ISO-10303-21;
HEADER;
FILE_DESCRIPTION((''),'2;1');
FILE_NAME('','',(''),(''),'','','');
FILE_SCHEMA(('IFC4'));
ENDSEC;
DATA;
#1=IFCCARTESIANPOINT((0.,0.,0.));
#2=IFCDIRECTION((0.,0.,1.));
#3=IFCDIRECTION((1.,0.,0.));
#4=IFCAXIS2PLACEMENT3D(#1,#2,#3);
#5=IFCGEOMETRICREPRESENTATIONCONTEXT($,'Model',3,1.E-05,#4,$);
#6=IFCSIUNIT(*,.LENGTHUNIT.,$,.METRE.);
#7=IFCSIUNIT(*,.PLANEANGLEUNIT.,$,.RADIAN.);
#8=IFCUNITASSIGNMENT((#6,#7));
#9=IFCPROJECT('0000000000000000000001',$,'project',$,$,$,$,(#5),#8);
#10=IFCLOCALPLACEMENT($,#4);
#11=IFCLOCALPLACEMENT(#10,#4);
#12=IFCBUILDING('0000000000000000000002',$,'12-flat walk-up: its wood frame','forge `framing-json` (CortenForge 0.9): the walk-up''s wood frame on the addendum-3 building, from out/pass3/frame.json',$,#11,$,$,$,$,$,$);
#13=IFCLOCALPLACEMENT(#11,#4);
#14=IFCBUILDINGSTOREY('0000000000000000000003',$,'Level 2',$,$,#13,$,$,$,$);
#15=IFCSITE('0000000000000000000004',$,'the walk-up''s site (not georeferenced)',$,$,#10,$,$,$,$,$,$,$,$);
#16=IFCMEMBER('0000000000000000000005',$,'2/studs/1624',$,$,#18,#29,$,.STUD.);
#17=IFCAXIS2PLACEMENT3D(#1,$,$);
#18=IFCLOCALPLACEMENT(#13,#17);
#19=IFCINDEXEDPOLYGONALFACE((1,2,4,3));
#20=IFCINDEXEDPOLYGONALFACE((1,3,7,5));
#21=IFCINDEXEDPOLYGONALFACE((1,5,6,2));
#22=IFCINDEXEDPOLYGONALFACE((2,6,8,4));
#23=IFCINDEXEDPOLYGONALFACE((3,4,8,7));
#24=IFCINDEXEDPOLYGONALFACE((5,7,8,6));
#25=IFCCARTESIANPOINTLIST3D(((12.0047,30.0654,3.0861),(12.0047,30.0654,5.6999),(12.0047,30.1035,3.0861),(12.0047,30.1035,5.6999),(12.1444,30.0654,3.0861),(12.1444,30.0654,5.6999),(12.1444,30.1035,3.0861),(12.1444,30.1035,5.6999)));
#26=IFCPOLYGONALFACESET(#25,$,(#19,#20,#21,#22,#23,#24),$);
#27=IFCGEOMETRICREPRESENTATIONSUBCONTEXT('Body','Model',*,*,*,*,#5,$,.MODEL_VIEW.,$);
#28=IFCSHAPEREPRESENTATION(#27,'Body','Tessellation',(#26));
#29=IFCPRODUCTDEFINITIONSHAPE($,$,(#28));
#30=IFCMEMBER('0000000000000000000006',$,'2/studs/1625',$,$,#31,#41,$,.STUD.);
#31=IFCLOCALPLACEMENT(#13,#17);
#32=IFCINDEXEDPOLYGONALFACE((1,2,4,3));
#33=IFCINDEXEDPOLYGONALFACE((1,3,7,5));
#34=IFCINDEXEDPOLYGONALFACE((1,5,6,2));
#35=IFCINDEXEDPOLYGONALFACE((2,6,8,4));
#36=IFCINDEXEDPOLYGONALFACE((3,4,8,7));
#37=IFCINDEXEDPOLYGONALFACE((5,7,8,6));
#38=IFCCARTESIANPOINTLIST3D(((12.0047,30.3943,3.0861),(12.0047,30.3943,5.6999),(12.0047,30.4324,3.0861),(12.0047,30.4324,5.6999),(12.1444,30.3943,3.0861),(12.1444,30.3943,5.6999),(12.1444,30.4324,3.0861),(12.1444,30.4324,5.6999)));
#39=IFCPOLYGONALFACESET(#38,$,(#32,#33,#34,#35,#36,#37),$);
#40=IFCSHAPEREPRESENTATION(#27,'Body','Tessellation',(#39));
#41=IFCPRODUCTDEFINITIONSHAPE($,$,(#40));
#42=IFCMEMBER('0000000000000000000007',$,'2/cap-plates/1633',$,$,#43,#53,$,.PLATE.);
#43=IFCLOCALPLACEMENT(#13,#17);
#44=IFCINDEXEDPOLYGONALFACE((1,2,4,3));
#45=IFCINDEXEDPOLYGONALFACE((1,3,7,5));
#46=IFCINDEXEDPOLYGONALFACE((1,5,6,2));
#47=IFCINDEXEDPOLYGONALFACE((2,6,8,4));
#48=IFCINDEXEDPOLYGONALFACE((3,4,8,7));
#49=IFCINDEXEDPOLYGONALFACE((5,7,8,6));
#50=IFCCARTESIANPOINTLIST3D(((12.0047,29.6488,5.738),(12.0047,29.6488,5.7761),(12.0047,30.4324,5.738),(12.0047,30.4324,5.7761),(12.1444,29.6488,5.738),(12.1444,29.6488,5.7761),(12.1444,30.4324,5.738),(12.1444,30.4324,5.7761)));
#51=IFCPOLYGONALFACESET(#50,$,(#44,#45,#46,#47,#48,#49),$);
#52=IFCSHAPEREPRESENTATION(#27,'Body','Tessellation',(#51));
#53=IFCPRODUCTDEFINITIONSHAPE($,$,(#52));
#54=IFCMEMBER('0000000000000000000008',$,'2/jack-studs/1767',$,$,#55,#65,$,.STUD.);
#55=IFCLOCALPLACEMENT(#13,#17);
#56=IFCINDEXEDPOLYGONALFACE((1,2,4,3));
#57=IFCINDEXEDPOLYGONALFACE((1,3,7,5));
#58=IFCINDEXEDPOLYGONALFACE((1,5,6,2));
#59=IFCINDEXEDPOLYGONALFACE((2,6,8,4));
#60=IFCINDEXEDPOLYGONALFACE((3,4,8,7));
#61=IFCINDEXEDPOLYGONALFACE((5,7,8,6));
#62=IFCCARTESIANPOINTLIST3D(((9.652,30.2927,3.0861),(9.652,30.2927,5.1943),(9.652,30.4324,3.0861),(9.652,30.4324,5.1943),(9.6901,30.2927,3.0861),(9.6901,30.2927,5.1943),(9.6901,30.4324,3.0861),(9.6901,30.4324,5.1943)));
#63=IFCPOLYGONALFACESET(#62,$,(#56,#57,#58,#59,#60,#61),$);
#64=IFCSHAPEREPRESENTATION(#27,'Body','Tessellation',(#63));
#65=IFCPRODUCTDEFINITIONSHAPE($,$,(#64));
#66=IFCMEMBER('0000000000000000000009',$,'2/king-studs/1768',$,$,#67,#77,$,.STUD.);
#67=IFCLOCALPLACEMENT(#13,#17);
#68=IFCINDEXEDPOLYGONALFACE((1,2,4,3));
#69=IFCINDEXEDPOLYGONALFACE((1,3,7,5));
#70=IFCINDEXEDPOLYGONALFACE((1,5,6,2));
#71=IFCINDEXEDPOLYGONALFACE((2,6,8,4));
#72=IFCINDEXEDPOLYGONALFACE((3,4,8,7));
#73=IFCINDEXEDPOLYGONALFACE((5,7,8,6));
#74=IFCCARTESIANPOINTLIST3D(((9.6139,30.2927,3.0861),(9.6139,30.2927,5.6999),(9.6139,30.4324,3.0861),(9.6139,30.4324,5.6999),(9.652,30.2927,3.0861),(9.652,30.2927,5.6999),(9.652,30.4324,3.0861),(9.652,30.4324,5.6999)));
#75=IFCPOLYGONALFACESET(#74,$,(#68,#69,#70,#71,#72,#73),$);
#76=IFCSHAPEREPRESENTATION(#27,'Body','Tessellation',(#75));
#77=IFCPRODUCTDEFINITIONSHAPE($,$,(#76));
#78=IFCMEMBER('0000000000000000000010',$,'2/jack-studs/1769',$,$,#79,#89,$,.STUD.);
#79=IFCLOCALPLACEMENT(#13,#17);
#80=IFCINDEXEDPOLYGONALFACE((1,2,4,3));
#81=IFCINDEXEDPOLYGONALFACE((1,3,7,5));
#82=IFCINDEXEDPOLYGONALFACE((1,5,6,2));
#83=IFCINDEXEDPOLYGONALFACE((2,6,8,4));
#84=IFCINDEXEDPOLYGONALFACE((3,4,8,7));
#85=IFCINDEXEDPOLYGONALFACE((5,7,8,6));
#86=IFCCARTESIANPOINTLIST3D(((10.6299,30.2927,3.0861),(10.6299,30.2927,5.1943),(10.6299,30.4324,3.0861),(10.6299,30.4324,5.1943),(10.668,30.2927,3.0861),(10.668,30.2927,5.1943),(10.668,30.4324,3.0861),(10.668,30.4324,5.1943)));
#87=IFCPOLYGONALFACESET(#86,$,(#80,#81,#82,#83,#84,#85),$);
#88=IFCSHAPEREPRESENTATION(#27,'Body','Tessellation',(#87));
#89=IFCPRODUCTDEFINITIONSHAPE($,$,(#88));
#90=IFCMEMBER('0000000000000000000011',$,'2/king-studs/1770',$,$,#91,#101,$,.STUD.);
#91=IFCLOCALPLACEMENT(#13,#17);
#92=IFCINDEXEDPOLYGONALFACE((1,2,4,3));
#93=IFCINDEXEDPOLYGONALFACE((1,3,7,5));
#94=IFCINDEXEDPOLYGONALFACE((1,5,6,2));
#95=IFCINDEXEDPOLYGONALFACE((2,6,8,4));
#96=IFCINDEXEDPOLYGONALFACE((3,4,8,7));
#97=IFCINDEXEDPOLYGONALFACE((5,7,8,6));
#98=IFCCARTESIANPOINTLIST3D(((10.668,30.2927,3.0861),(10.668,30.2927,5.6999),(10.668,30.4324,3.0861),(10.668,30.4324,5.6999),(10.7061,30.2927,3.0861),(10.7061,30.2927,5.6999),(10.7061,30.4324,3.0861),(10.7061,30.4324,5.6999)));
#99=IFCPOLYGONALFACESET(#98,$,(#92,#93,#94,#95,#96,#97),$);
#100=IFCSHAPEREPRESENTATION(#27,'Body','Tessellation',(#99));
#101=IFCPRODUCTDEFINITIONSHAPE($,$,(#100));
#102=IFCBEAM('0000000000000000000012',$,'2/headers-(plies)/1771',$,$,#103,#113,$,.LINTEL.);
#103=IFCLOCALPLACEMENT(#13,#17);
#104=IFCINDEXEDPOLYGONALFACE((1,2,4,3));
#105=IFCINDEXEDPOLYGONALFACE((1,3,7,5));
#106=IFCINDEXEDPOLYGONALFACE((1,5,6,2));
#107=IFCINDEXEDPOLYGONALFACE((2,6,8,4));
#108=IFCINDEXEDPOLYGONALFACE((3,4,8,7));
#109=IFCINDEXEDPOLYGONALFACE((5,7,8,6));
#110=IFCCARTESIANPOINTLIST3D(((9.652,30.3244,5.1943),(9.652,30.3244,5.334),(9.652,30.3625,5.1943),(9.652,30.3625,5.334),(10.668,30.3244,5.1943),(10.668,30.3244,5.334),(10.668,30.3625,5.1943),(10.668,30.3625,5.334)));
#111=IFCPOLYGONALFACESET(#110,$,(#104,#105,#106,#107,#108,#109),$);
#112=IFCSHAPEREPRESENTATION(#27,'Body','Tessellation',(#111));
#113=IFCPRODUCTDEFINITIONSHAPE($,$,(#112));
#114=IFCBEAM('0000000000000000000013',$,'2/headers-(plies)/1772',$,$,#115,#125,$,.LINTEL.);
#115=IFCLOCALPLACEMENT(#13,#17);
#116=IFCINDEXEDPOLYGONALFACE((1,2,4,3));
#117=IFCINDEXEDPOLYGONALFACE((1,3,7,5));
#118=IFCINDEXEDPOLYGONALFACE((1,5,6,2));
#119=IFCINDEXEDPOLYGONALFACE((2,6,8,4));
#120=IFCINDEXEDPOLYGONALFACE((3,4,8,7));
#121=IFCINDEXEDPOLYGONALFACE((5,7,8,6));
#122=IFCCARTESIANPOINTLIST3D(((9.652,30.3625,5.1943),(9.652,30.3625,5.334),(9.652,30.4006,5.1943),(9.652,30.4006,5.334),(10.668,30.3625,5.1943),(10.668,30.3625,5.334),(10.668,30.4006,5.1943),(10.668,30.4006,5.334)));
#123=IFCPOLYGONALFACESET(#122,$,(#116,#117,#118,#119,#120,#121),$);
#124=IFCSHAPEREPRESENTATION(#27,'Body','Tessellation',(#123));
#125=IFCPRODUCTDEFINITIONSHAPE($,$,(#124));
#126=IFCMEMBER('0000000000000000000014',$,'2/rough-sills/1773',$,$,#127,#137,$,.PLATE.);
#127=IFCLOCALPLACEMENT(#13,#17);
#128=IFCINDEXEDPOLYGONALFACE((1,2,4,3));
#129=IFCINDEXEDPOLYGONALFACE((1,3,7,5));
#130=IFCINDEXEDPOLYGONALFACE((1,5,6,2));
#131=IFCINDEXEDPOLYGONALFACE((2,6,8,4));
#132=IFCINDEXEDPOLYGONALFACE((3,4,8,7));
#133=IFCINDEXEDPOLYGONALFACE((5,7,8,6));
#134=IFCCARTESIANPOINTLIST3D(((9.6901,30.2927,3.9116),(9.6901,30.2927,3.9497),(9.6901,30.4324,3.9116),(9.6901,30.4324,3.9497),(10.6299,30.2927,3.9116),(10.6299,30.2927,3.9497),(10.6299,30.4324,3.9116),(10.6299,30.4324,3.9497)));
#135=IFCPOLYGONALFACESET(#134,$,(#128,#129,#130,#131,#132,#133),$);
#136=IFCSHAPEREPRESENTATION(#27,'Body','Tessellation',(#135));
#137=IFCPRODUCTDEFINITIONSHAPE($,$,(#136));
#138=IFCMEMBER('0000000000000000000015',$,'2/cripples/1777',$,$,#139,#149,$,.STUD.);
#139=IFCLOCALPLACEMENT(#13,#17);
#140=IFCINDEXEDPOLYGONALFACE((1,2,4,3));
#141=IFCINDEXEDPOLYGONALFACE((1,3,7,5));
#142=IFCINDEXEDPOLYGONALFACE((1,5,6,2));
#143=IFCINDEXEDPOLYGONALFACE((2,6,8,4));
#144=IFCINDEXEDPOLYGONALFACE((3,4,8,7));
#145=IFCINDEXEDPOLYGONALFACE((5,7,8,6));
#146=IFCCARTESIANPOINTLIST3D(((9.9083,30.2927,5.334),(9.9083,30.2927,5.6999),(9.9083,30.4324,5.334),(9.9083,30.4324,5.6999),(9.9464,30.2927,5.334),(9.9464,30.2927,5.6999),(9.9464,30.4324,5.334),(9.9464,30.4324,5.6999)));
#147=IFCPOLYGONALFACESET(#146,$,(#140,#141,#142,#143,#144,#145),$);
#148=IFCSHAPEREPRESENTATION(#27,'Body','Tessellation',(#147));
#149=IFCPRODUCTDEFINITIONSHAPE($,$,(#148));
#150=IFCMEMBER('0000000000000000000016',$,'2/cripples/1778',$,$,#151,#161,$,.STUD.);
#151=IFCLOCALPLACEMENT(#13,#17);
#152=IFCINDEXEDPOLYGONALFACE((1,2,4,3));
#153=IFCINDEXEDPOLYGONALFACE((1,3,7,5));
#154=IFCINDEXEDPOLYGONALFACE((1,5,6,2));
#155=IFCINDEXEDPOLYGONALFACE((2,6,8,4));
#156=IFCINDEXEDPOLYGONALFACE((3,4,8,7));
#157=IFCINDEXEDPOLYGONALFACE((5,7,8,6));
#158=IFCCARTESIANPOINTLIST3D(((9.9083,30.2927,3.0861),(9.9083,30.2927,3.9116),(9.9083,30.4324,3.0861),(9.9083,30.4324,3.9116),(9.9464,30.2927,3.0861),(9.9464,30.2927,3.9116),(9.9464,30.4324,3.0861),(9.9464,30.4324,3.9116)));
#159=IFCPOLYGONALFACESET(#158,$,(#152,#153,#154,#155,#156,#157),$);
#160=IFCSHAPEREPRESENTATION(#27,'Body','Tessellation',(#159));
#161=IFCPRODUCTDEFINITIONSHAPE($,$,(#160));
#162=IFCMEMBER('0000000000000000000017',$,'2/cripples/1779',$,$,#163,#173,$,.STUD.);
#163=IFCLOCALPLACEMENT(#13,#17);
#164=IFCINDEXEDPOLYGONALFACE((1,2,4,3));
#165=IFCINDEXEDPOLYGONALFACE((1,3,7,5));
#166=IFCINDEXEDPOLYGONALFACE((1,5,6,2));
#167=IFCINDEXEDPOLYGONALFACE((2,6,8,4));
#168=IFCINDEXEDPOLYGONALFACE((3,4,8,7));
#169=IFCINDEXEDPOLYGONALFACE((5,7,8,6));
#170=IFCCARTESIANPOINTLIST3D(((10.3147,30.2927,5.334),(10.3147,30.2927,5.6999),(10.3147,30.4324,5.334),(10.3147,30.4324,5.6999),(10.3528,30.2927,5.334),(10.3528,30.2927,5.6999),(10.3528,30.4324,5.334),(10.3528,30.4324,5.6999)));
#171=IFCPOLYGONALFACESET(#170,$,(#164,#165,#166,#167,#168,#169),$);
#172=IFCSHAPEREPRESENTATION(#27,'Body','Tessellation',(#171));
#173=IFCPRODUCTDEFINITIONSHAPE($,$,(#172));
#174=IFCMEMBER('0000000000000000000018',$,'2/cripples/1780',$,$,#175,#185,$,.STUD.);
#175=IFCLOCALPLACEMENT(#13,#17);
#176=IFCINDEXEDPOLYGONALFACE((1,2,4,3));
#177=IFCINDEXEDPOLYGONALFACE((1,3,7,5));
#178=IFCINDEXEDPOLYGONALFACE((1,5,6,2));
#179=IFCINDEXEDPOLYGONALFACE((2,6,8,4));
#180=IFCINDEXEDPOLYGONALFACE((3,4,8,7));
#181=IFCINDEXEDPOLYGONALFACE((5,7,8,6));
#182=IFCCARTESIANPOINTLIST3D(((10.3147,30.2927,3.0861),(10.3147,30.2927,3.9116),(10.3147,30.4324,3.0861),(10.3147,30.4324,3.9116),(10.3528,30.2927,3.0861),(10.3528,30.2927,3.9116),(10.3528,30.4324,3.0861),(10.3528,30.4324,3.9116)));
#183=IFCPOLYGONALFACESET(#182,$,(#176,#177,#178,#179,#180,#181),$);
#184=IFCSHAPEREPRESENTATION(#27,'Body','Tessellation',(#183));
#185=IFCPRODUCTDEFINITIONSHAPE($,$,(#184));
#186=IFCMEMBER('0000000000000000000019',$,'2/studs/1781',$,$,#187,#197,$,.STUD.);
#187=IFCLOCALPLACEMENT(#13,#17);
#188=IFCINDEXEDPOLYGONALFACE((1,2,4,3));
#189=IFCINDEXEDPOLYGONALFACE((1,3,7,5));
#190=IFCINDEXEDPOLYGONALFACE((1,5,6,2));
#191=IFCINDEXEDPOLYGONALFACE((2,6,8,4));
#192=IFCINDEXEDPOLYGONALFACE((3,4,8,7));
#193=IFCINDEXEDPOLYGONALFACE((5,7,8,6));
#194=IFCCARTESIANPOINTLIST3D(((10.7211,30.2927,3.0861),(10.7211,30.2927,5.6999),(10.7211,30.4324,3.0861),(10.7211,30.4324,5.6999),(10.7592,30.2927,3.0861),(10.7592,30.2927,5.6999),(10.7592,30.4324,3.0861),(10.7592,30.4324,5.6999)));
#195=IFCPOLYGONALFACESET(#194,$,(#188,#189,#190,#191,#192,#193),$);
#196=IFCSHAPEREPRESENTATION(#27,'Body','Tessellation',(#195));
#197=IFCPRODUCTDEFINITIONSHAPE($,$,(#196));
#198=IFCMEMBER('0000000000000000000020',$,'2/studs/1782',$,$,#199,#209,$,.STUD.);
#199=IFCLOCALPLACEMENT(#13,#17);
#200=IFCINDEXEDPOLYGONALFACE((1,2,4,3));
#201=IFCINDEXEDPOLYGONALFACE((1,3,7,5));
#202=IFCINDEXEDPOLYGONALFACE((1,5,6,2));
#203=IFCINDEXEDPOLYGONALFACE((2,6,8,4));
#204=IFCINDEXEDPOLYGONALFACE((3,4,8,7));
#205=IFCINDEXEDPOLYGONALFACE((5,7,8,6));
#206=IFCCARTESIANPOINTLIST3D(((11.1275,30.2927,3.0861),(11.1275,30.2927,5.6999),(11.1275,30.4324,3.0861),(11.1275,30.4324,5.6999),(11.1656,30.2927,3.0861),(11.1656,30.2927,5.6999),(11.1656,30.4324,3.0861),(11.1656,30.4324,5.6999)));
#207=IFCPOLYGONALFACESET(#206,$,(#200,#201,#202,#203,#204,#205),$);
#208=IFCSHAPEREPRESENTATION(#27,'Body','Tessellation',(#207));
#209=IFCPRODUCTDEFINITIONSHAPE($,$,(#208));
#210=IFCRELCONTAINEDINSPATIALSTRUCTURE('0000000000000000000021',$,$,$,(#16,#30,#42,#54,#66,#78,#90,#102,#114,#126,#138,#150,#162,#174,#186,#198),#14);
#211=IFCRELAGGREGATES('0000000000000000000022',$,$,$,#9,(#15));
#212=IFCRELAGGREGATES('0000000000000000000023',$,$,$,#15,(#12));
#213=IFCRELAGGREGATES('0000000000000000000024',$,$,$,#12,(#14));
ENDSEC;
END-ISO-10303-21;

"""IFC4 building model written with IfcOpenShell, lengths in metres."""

from ifc_helpers import new_model, si_unit, frame, frame_2d, origin, origin_with_axes, place, context, subcontext, project, spatial, rectangle, extrude, element, save


model = new_model("IFC4")

# Units and contexts
model_context = context("Model", 3, precision=1e-05, world=origin_with_axes())
body_context = subcontext(model_context, "Body", "Model", "MODEL_VIEW")
ifc_project = project(units=[si_unit("LENGTHUNIT", "METRE"), si_unit("PLANEANGLEUNIT", "RADIAN")], contexts=[model_context])

# Site, building, storey
site_placement = place(None, origin_with_axes())
site = spatial("IfcSite", under=ifc_project, at=site_placement, Name="the walk-up's site (not georeferenced)")
building_placement = place(site_placement, origin_with_axes())
building = spatial("IfcBuilding", under=site, at=building_placement, Name="12-flat walk-up: its wood frame", Description="forge `framing-json` (CortenForge 0.9): the walk-up's wood frame on the addendum-3 building, from out/pass3/frame.json")
storey_placement = place(building_placement, origin_with_axes())
storey = spatial("IfcBuildingStorey", under=building, at=storey_placement, Name="Level 2")

# Members
for number, where, z_axis, x_axis, name in (
    (1, (12.0047, 30.0654, 3.0861), (0.0, 0.0, 1.0), (1.0, 0.0, 0.0), "2/studs/1624"),
    (2, (12.0047, 30.3943, 3.0861), (0.0, 0.0, 1.0), (1.0, 0.0, 0.0), "2/studs/1625"),
):
    element("IfcMember", number, at=place(storey_placement, frame(where, z_axis=z_axis, x_axis=x_axis)), inside=storey, Name=name, PredefinedType="STUD", context=body_context, shape_type="SweptSolid", body=[
        extrude(rectangle(XDim=0.1397, YDim=0.0381, at=frame_2d((0.0698, 0.0191))), origin(), (0.0, 0.0, 1.0), 2.6138),
    ])
member_1_placement = place(storey_placement, frame((12.0047, 29.6488, 5.738), z_axis=(0.0, 0.0, 1.0), x_axis=(1.0, 0.0, 0.0)))
element("IfcMember", 3, at=member_1_placement, inside=storey, Name="2/cap-plates/1633", PredefinedType="PLATE", context=body_context, shape_type="SweptSolid", body=[
    extrude(rectangle(XDim=0.1397, YDim=0.7836, at=frame_2d((0.0698, 0.3918))), origin(), (0.0, 0.0, 1.0), 0.0381),
])
member_2_placement = place(storey_placement, frame((9.652, 30.2927, 3.0861), z_axis=(0.0, 0.0, 1.0), x_axis=(1.0, 0.0, 0.0)))
element("IfcMember", 4, at=member_2_placement, inside=storey, Name="2/jack-studs/1767", PredefinedType="STUD", context=body_context, shape_type="SweptSolid", body=[
    extrude(rectangle(XDim=0.0381, YDim=0.1397, at=frame_2d((0.0191, 0.0699))), origin(), (0.0, 0.0, 1.0), 2.1082),
])
member_3_placement = place(storey_placement, frame((9.6139, 30.2927, 3.0861), z_axis=(0.0, 0.0, 1.0), x_axis=(1.0, 0.0, 0.0)))
element("IfcMember", 5, at=member_3_placement, inside=storey, Name="2/king-studs/1768", PredefinedType="STUD", context=body_context, shape_type="SweptSolid", body=[
    extrude(rectangle(XDim=0.0381, YDim=0.1397, at=frame_2d((0.0191, 0.0699))), origin(), (0.0, 0.0, 1.0), 2.6138),
])
member_4_placement = place(storey_placement, frame((10.6299, 30.2927, 3.0861), z_axis=(0.0, 0.0, 1.0), x_axis=(1.0, 0.0, 0.0)))
element("IfcMember", 6, at=member_4_placement, inside=storey, Name="2/jack-studs/1769", PredefinedType="STUD", context=body_context, shape_type="SweptSolid", body=[
    extrude(rectangle(XDim=0.0381, YDim=0.1397, at=frame_2d((0.0191, 0.0699))), origin(), (0.0, 0.0, 1.0), 2.1082),
])
member_5_placement = place(storey_placement, frame((10.668, 30.2927, 3.0861), z_axis=(0.0, 0.0, 1.0), x_axis=(1.0, 0.0, 0.0)))
element("IfcMember", 7, at=member_5_placement, inside=storey, Name="2/king-studs/1770", PredefinedType="STUD", context=body_context, shape_type="SweptSolid", body=[
    extrude(rectangle(XDim=0.0381, YDim=0.1397, at=frame_2d((0.0191, 0.0699))), origin(), (0.0, 0.0, 1.0), 2.6138),
])

# Beams
for number, where, z_axis, x_axis, name in (
    (8, (9.652, 30.3244, 5.1943), (0.0, 0.0, 1.0), (1.0, 0.0, 0.0), "2/headers-(plies)/1771"),
    (9, (9.652, 30.3625, 5.1943), (0.0, 0.0, 1.0), (1.0, 0.0, 0.0), "2/headers-(plies)/1772"),
):
    element("IfcBeam", number, at=place(storey_placement, frame(where, z_axis=z_axis, x_axis=x_axis)), inside=storey, Name=name, PredefinedType="LINTEL", context=body_context, shape_type="SweptSolid", body=[
        extrude(rectangle(XDim=1.016, YDim=0.0381, at=frame_2d((0.508, 0.0191))), origin(), (0.0, 0.0, 1.0), 0.1397),
    ])

# Members
member_6_placement = place(storey_placement, frame((9.6901, 30.2927, 3.9116), z_axis=(0.0, 0.0, 1.0), x_axis=(1.0, 0.0, 0.0)))
element("IfcMember", 10, at=member_6_placement, inside=storey, Name="2/rough-sills/1773", PredefinedType="PLATE", context=body_context, shape_type="SweptSolid", body=[
    extrude(rectangle(XDim=0.9398, YDim=0.1397, at=frame_2d((0.4699, 0.0699))), origin(), (0.0, 0.0, 1.0), 0.0381),
])
member_7_placement = place(storey_placement, frame((9.9083, 30.2927, 5.334), z_axis=(0.0, 0.0, 1.0), x_axis=(1.0, 0.0, 0.0)))
element("IfcMember", 11, at=member_7_placement, inside=storey, Name="2/cripples/1777", PredefinedType="STUD", context=body_context, shape_type="SweptSolid", body=[
    extrude(rectangle(XDim=0.0381, YDim=0.1397, at=frame_2d((0.0191, 0.0699))), origin(), (0.0, 0.0, 1.0), 0.3659),
])
member_8_placement = place(storey_placement, frame((9.9083, 30.2927, 3.0861), z_axis=(0.0, 0.0, 1.0), x_axis=(1.0, 0.0, 0.0)))
element("IfcMember", 12, at=member_8_placement, inside=storey, Name="2/cripples/1778", PredefinedType="STUD", context=body_context, shape_type="SweptSolid", body=[
    extrude(rectangle(XDim=0.0381, YDim=0.1397, at=frame_2d((0.0191, 0.0699))), origin(), (0.0, 0.0, 1.0), 0.8255),
])
member_9_placement = place(storey_placement, frame((10.3147, 30.2927, 5.334), z_axis=(0.0, 0.0, 1.0), x_axis=(1.0, 0.0, 0.0)))
element("IfcMember", 13, at=member_9_placement, inside=storey, Name="2/cripples/1779", PredefinedType="STUD", context=body_context, shape_type="SweptSolid", body=[
    extrude(rectangle(XDim=0.0381, YDim=0.1397, at=frame_2d((0.0191, 0.0699))), origin(), (0.0, 0.0, 1.0), 0.3659),
])
member_10_placement = place(storey_placement, frame((10.3147, 30.2927, 3.0861), z_axis=(0.0, 0.0, 1.0), x_axis=(1.0, 0.0, 0.0)))
element("IfcMember", 14, at=member_10_placement, inside=storey, Name="2/cripples/1780", PredefinedType="STUD", context=body_context, shape_type="SweptSolid", body=[
    extrude(rectangle(XDim=0.0381, YDim=0.1397, at=frame_2d((0.0191, 0.0699))), origin(), (0.0, 0.0, 1.0), 0.8255),
])
for number, where, z_axis, x_axis, name in (
    (15, (10.7211, 30.2927, 3.0861), (0.0, 0.0, 1.0), (1.0, 0.0, 0.0), "2/studs/1781"),
    (16, (11.1275, 30.2927, 3.0861), (0.0, 0.0, 1.0), (1.0, 0.0, 0.0), "2/studs/1782"),
):
    element("IfcMember", number, at=place(storey_placement, frame(where, z_axis=z_axis, x_axis=x_axis)), inside=storey, Name=name, PredefinedType="STUD", context=body_context, shape_type="SweptSolid", body=[
        extrude(rectangle(XDim=0.0381, YDim=0.1397, at=frame_2d((0.0191, 0.0699))), origin(), (0.0, 0.0, 1.0), 2.6138),
    ])

save(model, "model.ifc")
